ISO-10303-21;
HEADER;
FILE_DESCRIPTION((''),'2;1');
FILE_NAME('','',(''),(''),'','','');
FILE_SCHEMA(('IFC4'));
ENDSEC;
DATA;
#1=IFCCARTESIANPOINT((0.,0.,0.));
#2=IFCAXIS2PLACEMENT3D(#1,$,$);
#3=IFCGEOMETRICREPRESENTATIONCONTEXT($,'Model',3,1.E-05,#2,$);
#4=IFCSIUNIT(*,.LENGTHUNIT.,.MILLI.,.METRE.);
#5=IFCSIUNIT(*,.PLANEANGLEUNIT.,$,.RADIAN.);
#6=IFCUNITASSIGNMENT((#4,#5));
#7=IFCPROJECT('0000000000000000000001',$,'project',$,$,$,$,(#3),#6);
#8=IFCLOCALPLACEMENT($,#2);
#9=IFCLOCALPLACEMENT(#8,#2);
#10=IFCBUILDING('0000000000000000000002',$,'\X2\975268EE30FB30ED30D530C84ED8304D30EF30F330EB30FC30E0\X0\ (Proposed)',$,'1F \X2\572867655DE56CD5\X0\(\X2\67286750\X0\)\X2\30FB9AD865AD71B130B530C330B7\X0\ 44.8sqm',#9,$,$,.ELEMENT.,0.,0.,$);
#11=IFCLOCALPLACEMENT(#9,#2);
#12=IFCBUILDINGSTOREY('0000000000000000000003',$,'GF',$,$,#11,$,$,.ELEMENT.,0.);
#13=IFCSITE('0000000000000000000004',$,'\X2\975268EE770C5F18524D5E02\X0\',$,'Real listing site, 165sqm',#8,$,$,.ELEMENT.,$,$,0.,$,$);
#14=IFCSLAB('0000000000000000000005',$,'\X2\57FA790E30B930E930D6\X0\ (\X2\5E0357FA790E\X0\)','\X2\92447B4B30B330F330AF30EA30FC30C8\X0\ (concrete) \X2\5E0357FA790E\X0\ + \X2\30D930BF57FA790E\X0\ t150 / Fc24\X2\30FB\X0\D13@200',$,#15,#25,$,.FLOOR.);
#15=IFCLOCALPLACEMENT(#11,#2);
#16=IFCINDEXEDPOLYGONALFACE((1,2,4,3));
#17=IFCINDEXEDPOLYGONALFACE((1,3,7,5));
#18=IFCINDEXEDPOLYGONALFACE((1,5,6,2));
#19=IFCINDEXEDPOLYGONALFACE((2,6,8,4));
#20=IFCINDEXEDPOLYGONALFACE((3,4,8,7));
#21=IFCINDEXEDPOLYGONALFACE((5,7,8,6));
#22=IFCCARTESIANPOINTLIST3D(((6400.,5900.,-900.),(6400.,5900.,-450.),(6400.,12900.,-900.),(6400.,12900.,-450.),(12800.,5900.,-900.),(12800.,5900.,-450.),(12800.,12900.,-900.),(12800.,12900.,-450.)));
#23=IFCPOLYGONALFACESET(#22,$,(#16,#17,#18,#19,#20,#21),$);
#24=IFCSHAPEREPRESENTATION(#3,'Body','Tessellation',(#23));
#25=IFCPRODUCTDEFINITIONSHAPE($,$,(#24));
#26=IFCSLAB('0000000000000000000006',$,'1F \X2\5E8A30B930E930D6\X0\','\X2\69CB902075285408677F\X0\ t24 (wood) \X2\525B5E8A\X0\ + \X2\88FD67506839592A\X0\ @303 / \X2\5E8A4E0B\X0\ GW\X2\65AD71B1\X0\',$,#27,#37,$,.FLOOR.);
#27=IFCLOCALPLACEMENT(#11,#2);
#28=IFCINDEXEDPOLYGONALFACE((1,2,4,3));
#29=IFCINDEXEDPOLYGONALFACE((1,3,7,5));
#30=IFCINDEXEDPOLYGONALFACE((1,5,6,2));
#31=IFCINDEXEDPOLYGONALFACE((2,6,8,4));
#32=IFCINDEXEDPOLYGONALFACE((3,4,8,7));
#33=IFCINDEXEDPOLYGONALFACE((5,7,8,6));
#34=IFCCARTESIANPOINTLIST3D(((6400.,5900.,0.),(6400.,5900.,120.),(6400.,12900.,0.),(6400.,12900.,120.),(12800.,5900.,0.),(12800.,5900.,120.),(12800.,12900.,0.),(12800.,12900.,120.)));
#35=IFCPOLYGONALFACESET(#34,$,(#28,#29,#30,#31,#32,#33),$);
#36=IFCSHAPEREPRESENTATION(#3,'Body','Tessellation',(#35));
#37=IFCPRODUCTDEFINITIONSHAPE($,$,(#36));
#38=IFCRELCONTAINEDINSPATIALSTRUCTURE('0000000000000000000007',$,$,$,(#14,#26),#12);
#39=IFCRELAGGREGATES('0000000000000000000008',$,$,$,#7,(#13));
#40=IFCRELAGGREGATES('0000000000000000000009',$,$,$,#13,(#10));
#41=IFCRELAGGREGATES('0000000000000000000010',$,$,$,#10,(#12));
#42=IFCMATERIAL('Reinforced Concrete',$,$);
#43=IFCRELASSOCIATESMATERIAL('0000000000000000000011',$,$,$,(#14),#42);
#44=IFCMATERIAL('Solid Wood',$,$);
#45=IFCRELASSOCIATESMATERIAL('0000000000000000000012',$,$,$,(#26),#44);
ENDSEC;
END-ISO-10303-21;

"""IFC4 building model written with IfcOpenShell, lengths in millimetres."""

from ifc_helpers import new_model, si_unit, frame, frame_2d, origin, place, context, project, spatial, rectangle, extrude, material, element, save


model = new_model("IFC4")

# Units and contexts
model_context = context("Model", 3, precision=1e-05, world=origin())
ifc_project = project(units=[si_unit("LENGTHUNIT", "METRE", prefix="MILLI"), si_unit("PLANEANGLEUNIT", "RADIAN")], contexts=[model_context])

# Site, building, storey
site_placement = place(None, origin())
site = spatial("IfcSite", under=ifc_project, at=site_placement, Name="青森県弘前市", ObjectType="Real listing site, 165sqm", CompositionType="ELEMENT", RefElevation=0.0)
building_placement = place(site_placement, origin())
building = spatial("IfcBuilding", under=site, at=building_placement, Name="青森・ロフト付きワンルーム (Proposed)", ObjectType="1F 在来工法(木材)・高断熱サッシ 44.8sqm", CompositionType="ELEMENT", ElevationOfRefHeight=0.0, ElevationOfTerrain=0.0)
storey_placement = place(building_placement, origin())
storey = spatial("IfcBuildingStorey", under=building, at=storey_placement, Name="GF", CompositionType="ELEMENT", Elevation=0.0)

# Shared definitions
ifc_material_1 = material(Name="Solid Wood")

# Slabs
ifc_material_2 = material(Name="Reinforced Concrete")
slab_1_placement = place(storey_placement, frame((3200.0, 2950.0, -450.0)))
element("IfcSlab", 1, at=slab_1_placement, inside=storey, material=ifc_material_2, Name="基礎スラブ (布基礎)", Description="鉄筋コンクリート (concrete) 布基礎 + ベタ基礎 t150 / Fc24・D13@200", PredefinedType="FLOOR", context=model_context, shape_type="SweptSolid", body=[
    extrude(rectangle(XDim=6400.0, YDim=7000.0, at=frame_2d((3200.0, 3500.0))), frame((3200.0, 2950.0, -450.0)), (0.0, 0.0, 1.0), 450.0),
])
slab_2_placement = place(storey_placement, frame((3200.0, 2950.0, 0.0)))
element("IfcSlab", 2, at=slab_2_placement, inside=storey, material=ifc_material_1, Name="1F 床スラブ", Description="構造用合板 t24 (wood) 剛床 + 製材根太 @303 / 床下 GW断熱", PredefinedType="FLOOR", context=model_context, shape_type="SweptSolid", body=[
    extrude(rectangle(XDim=6400.0, YDim=7000.0, at=frame_2d((3200.0, 3500.0))), frame((3200.0, 2950.0, 0.0)), (0.0, 0.0, 1.0), 120.0),
])

save(model, "model.ifc")
